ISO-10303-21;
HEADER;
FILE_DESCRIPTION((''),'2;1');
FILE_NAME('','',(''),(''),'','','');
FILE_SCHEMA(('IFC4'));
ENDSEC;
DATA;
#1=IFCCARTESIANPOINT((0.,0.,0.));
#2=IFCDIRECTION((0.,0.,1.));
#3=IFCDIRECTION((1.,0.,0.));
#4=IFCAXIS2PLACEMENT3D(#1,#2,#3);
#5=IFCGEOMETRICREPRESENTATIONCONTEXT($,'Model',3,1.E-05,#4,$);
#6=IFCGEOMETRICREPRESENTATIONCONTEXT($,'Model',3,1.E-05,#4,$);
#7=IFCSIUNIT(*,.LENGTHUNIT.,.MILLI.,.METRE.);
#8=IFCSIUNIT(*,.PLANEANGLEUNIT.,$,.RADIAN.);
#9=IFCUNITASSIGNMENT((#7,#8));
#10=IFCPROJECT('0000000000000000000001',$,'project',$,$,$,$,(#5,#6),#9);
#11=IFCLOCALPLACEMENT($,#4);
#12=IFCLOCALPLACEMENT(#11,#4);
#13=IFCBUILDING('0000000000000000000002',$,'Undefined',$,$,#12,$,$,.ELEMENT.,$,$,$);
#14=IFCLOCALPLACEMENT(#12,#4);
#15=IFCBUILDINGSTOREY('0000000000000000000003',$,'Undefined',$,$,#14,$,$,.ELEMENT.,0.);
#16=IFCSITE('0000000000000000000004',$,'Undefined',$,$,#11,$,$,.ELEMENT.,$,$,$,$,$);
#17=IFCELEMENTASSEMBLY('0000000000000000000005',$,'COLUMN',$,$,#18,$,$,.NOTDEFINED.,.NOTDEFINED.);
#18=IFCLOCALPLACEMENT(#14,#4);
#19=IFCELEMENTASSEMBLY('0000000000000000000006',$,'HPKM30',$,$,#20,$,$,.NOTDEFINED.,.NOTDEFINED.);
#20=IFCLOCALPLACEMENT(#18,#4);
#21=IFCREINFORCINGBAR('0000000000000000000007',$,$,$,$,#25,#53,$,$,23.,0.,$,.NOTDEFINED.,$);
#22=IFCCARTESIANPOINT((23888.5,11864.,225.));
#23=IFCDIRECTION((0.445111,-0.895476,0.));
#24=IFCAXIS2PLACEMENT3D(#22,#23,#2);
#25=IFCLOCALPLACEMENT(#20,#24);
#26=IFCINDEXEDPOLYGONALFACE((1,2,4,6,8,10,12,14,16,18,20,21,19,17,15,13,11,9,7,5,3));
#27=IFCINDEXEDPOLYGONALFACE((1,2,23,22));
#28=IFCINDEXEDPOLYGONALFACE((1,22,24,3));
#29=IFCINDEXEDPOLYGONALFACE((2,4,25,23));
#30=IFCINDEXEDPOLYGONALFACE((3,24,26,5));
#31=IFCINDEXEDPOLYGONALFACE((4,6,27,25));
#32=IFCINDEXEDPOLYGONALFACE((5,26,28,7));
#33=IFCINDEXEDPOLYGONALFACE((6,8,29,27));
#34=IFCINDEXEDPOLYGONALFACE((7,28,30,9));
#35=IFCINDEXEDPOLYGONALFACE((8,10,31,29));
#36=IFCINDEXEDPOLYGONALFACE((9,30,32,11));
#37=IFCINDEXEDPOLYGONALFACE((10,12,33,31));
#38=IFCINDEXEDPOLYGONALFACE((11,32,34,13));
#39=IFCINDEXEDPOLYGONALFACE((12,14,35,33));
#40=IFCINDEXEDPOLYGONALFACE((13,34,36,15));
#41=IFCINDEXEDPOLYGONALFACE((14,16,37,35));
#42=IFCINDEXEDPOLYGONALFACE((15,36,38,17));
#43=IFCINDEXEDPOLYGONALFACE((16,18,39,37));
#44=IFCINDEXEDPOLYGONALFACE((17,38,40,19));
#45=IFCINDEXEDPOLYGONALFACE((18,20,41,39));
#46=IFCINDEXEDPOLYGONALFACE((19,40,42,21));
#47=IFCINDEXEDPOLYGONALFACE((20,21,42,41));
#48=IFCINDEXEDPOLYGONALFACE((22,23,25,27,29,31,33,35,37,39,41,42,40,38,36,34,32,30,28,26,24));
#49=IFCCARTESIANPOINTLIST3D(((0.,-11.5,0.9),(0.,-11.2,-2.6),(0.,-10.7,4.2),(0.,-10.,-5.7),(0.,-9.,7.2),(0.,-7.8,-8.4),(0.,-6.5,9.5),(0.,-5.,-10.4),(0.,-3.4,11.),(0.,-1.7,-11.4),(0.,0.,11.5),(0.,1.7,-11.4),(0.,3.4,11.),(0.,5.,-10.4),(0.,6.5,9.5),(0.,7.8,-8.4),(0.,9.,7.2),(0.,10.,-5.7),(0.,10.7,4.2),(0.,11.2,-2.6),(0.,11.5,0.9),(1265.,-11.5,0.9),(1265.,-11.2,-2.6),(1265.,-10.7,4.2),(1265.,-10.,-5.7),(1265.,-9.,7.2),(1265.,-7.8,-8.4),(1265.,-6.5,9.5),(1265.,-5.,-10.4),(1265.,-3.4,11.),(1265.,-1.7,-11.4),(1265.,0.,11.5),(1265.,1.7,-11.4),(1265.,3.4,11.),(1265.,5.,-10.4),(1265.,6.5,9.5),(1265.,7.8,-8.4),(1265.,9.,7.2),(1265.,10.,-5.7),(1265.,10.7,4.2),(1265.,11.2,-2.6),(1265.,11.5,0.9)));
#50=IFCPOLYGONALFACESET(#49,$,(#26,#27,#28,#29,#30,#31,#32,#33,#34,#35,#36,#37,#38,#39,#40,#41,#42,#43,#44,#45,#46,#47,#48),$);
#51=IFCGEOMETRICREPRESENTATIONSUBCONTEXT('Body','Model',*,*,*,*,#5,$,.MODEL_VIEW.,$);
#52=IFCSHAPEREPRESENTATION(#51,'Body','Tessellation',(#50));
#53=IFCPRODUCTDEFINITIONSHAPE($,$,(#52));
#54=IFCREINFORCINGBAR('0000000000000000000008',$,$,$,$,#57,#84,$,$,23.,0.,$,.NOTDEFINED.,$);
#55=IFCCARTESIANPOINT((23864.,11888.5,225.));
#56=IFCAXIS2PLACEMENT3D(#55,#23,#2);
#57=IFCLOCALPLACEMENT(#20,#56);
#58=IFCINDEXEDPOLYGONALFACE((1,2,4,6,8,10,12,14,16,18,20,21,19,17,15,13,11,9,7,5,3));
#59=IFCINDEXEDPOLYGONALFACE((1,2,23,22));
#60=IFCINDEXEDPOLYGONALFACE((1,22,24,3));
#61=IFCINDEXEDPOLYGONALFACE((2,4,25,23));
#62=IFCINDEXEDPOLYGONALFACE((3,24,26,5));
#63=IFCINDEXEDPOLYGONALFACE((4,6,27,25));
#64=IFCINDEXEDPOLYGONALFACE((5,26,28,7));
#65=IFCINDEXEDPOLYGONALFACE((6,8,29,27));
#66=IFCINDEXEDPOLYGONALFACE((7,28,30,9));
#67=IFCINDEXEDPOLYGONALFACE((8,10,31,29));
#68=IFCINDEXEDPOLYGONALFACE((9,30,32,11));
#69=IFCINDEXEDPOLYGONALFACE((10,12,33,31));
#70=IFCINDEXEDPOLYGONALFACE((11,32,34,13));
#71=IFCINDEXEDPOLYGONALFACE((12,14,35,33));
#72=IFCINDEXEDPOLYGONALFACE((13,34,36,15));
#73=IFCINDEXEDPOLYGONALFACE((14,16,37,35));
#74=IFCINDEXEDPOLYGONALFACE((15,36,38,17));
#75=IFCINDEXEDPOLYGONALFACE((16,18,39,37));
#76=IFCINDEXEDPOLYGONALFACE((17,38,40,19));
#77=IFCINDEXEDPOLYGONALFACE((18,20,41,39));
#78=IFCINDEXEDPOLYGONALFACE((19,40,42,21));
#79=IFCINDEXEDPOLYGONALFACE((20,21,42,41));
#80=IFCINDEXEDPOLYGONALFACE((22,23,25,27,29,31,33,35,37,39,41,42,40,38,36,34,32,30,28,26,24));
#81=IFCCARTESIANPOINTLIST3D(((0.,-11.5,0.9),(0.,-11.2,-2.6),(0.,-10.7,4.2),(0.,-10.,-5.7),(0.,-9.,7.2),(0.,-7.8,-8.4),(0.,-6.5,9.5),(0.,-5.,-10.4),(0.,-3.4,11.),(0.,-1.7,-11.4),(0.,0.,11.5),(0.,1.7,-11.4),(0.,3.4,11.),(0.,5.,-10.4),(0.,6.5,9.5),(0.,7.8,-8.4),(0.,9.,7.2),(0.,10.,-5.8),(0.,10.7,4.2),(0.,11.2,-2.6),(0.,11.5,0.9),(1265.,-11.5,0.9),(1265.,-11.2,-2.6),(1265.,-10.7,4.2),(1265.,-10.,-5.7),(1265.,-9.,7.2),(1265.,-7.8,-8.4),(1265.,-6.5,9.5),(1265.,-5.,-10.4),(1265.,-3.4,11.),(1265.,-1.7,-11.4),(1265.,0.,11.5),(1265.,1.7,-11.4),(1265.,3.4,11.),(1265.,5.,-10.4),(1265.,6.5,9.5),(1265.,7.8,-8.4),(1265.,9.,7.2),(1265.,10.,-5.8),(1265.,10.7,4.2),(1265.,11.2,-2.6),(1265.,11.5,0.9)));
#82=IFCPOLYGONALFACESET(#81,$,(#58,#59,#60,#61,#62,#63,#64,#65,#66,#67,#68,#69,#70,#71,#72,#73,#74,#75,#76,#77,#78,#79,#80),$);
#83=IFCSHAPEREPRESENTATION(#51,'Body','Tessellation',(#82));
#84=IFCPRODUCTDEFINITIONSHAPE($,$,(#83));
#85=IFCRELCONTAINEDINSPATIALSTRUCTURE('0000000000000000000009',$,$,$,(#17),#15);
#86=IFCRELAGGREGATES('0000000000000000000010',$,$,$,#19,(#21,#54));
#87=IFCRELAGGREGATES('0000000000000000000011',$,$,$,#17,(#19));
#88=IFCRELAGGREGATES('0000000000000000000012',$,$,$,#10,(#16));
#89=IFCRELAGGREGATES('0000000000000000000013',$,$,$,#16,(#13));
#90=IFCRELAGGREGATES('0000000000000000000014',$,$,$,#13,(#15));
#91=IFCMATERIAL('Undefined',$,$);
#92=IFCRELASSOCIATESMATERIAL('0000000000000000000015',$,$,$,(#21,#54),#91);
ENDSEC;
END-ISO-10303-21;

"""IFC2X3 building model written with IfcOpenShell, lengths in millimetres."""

from ifc_helpers import new_model, entity, si_unit, frame, origin_with_axes, place, context, subcontext, project, spatial, source, transform, mapped, material, element, aggregate, save


model = new_model("IFC2X3")

# Units and contexts
model_context_1 = context("Model", 3, precision=1e-05, world=origin_with_axes())
model_context_2 = context("Model", 3, precision=1e-05, world=origin_with_axes())
body_context = subcontext(model_context_1, "Body", "Model", "MODEL_VIEW")
ifc_project = project(units=[si_unit("LENGTHUNIT", "METRE", prefix="MILLI"), si_unit("PLANEANGLEUNIT", "RADIAN")], contexts=[model_context_1, model_context_2])

# Site, building, storey
site_placement = place(None, origin_with_axes())
site = spatial("IfcSite", under=ifc_project, at=site_placement, Name="Undefined", CompositionType="ELEMENT")
building_placement = place(site_placement, origin_with_axes())
building = spatial("IfcBuilding", under=site, at=building_placement, Name="Undefined", CompositionType="ELEMENT")
storey_placement = place(building_placement, origin_with_axes())
storey = spatial("IfcBuildingStorey", under=building, at=storey_placement, Name="Undefined", CompositionType="ELEMENT", Elevation=0.0)

# Element assembly
assembly_1_placement = place(storey_placement, origin_with_axes())
assembly_1 = element("IfcElementAssembly", 1, at=assembly_1_placement, inside=storey, Name="COLUMN", AssemblyPlace="NOTDEFINED", PredefinedType="NOTDEFINED")

# Element assembly
assembly_2_placement = place(assembly_1_placement, origin_with_axes())
assembly_2 = element("IfcElementAssembly", 2, at=assembly_2_placement, Name="HPKM30", AssemblyPlace="NOTDEFINED", PredefinedType="NOTDEFINED")

# Shared definitions
ifc_material_1 = material(Name="Undefined")

# Reinforcing bars
shared_shape_1 = source(origin_with_axes(), body_context, "Body", "AdvancedSweptSolid", [
    entity("IfcSweptDiskSolid", entity("IfcTrimmedCurve", entity("IfcLine", entity("IfcCartesianPoint", [0.0, 0.0, 0.0]), entity("IfcVector", entity("IfcDirection", [1.0, 0.0, 0.0]), 1.0)), [entity("IfcParameterValue", 0.0)], [entity("IfcParameterValue", 1265.0)], True, "PARAMETER"), 11.5, None, 0.0, 1265.0),
])
reinforcing_bar_1_placement = place(assembly_2_placement, frame((23888.5, 11864.0, 225.0), z_axis=(0.445111, -0.895476, 0.0), x_axis=(0.0, 0.0, 1.0)))
reinforcing_bar_1 = element("IfcReinforcingBar", 3, at=reinforcing_bar_1_placement, material=ifc_material_1, BarRole="NOTDEFINED", CrossSectionArea=0.0, NominalDiameter=23.0, context=body_context, shape_type="MappedRepresentation", body=[
    mapped(shared_shape_1, transform((0.0, 0.0, 0.0))),
])
shared_shape_2 = source(origin_with_axes(), body_context, "Body", "AdvancedSweptSolid", [
    entity("IfcSweptDiskSolid", entity("IfcTrimmedCurve", entity("IfcLine", entity("IfcCartesianPoint", [0.0, 0.0, 0.0]), entity("IfcVector", entity("IfcDirection", [1.0, 0.0, 0.0]), 1.0)), [entity("IfcParameterValue", 0.0)], [entity("IfcParameterValue", 1265.0)], True, "PARAMETER"), 11.5, None, 0.0, 1265.0),
])
reinforcing_bar_2_placement = place(assembly_2_placement, frame((23864.0, 11888.5, 225.0), z_axis=(0.445111, -0.895476, 0.0), x_axis=(0.0, 0.0, 1.0)))
reinforcing_bar_2 = element("IfcReinforcingBar", 4, at=reinforcing_bar_2_placement, material=ifc_material_1, BarRole="NOTDEFINED", CrossSectionArea=0.0, NominalDiameter=23.0, context=body_context, shape_type="MappedRepresentation", body=[
    mapped(shared_shape_2, transform((0.0, 0.0, 0.0))),
])
aggregate(assembly_2, [reinforcing_bar_1, reinforcing_bar_2])
aggregate(assembly_1, [assembly_2])

save(model, "model.ifc")
